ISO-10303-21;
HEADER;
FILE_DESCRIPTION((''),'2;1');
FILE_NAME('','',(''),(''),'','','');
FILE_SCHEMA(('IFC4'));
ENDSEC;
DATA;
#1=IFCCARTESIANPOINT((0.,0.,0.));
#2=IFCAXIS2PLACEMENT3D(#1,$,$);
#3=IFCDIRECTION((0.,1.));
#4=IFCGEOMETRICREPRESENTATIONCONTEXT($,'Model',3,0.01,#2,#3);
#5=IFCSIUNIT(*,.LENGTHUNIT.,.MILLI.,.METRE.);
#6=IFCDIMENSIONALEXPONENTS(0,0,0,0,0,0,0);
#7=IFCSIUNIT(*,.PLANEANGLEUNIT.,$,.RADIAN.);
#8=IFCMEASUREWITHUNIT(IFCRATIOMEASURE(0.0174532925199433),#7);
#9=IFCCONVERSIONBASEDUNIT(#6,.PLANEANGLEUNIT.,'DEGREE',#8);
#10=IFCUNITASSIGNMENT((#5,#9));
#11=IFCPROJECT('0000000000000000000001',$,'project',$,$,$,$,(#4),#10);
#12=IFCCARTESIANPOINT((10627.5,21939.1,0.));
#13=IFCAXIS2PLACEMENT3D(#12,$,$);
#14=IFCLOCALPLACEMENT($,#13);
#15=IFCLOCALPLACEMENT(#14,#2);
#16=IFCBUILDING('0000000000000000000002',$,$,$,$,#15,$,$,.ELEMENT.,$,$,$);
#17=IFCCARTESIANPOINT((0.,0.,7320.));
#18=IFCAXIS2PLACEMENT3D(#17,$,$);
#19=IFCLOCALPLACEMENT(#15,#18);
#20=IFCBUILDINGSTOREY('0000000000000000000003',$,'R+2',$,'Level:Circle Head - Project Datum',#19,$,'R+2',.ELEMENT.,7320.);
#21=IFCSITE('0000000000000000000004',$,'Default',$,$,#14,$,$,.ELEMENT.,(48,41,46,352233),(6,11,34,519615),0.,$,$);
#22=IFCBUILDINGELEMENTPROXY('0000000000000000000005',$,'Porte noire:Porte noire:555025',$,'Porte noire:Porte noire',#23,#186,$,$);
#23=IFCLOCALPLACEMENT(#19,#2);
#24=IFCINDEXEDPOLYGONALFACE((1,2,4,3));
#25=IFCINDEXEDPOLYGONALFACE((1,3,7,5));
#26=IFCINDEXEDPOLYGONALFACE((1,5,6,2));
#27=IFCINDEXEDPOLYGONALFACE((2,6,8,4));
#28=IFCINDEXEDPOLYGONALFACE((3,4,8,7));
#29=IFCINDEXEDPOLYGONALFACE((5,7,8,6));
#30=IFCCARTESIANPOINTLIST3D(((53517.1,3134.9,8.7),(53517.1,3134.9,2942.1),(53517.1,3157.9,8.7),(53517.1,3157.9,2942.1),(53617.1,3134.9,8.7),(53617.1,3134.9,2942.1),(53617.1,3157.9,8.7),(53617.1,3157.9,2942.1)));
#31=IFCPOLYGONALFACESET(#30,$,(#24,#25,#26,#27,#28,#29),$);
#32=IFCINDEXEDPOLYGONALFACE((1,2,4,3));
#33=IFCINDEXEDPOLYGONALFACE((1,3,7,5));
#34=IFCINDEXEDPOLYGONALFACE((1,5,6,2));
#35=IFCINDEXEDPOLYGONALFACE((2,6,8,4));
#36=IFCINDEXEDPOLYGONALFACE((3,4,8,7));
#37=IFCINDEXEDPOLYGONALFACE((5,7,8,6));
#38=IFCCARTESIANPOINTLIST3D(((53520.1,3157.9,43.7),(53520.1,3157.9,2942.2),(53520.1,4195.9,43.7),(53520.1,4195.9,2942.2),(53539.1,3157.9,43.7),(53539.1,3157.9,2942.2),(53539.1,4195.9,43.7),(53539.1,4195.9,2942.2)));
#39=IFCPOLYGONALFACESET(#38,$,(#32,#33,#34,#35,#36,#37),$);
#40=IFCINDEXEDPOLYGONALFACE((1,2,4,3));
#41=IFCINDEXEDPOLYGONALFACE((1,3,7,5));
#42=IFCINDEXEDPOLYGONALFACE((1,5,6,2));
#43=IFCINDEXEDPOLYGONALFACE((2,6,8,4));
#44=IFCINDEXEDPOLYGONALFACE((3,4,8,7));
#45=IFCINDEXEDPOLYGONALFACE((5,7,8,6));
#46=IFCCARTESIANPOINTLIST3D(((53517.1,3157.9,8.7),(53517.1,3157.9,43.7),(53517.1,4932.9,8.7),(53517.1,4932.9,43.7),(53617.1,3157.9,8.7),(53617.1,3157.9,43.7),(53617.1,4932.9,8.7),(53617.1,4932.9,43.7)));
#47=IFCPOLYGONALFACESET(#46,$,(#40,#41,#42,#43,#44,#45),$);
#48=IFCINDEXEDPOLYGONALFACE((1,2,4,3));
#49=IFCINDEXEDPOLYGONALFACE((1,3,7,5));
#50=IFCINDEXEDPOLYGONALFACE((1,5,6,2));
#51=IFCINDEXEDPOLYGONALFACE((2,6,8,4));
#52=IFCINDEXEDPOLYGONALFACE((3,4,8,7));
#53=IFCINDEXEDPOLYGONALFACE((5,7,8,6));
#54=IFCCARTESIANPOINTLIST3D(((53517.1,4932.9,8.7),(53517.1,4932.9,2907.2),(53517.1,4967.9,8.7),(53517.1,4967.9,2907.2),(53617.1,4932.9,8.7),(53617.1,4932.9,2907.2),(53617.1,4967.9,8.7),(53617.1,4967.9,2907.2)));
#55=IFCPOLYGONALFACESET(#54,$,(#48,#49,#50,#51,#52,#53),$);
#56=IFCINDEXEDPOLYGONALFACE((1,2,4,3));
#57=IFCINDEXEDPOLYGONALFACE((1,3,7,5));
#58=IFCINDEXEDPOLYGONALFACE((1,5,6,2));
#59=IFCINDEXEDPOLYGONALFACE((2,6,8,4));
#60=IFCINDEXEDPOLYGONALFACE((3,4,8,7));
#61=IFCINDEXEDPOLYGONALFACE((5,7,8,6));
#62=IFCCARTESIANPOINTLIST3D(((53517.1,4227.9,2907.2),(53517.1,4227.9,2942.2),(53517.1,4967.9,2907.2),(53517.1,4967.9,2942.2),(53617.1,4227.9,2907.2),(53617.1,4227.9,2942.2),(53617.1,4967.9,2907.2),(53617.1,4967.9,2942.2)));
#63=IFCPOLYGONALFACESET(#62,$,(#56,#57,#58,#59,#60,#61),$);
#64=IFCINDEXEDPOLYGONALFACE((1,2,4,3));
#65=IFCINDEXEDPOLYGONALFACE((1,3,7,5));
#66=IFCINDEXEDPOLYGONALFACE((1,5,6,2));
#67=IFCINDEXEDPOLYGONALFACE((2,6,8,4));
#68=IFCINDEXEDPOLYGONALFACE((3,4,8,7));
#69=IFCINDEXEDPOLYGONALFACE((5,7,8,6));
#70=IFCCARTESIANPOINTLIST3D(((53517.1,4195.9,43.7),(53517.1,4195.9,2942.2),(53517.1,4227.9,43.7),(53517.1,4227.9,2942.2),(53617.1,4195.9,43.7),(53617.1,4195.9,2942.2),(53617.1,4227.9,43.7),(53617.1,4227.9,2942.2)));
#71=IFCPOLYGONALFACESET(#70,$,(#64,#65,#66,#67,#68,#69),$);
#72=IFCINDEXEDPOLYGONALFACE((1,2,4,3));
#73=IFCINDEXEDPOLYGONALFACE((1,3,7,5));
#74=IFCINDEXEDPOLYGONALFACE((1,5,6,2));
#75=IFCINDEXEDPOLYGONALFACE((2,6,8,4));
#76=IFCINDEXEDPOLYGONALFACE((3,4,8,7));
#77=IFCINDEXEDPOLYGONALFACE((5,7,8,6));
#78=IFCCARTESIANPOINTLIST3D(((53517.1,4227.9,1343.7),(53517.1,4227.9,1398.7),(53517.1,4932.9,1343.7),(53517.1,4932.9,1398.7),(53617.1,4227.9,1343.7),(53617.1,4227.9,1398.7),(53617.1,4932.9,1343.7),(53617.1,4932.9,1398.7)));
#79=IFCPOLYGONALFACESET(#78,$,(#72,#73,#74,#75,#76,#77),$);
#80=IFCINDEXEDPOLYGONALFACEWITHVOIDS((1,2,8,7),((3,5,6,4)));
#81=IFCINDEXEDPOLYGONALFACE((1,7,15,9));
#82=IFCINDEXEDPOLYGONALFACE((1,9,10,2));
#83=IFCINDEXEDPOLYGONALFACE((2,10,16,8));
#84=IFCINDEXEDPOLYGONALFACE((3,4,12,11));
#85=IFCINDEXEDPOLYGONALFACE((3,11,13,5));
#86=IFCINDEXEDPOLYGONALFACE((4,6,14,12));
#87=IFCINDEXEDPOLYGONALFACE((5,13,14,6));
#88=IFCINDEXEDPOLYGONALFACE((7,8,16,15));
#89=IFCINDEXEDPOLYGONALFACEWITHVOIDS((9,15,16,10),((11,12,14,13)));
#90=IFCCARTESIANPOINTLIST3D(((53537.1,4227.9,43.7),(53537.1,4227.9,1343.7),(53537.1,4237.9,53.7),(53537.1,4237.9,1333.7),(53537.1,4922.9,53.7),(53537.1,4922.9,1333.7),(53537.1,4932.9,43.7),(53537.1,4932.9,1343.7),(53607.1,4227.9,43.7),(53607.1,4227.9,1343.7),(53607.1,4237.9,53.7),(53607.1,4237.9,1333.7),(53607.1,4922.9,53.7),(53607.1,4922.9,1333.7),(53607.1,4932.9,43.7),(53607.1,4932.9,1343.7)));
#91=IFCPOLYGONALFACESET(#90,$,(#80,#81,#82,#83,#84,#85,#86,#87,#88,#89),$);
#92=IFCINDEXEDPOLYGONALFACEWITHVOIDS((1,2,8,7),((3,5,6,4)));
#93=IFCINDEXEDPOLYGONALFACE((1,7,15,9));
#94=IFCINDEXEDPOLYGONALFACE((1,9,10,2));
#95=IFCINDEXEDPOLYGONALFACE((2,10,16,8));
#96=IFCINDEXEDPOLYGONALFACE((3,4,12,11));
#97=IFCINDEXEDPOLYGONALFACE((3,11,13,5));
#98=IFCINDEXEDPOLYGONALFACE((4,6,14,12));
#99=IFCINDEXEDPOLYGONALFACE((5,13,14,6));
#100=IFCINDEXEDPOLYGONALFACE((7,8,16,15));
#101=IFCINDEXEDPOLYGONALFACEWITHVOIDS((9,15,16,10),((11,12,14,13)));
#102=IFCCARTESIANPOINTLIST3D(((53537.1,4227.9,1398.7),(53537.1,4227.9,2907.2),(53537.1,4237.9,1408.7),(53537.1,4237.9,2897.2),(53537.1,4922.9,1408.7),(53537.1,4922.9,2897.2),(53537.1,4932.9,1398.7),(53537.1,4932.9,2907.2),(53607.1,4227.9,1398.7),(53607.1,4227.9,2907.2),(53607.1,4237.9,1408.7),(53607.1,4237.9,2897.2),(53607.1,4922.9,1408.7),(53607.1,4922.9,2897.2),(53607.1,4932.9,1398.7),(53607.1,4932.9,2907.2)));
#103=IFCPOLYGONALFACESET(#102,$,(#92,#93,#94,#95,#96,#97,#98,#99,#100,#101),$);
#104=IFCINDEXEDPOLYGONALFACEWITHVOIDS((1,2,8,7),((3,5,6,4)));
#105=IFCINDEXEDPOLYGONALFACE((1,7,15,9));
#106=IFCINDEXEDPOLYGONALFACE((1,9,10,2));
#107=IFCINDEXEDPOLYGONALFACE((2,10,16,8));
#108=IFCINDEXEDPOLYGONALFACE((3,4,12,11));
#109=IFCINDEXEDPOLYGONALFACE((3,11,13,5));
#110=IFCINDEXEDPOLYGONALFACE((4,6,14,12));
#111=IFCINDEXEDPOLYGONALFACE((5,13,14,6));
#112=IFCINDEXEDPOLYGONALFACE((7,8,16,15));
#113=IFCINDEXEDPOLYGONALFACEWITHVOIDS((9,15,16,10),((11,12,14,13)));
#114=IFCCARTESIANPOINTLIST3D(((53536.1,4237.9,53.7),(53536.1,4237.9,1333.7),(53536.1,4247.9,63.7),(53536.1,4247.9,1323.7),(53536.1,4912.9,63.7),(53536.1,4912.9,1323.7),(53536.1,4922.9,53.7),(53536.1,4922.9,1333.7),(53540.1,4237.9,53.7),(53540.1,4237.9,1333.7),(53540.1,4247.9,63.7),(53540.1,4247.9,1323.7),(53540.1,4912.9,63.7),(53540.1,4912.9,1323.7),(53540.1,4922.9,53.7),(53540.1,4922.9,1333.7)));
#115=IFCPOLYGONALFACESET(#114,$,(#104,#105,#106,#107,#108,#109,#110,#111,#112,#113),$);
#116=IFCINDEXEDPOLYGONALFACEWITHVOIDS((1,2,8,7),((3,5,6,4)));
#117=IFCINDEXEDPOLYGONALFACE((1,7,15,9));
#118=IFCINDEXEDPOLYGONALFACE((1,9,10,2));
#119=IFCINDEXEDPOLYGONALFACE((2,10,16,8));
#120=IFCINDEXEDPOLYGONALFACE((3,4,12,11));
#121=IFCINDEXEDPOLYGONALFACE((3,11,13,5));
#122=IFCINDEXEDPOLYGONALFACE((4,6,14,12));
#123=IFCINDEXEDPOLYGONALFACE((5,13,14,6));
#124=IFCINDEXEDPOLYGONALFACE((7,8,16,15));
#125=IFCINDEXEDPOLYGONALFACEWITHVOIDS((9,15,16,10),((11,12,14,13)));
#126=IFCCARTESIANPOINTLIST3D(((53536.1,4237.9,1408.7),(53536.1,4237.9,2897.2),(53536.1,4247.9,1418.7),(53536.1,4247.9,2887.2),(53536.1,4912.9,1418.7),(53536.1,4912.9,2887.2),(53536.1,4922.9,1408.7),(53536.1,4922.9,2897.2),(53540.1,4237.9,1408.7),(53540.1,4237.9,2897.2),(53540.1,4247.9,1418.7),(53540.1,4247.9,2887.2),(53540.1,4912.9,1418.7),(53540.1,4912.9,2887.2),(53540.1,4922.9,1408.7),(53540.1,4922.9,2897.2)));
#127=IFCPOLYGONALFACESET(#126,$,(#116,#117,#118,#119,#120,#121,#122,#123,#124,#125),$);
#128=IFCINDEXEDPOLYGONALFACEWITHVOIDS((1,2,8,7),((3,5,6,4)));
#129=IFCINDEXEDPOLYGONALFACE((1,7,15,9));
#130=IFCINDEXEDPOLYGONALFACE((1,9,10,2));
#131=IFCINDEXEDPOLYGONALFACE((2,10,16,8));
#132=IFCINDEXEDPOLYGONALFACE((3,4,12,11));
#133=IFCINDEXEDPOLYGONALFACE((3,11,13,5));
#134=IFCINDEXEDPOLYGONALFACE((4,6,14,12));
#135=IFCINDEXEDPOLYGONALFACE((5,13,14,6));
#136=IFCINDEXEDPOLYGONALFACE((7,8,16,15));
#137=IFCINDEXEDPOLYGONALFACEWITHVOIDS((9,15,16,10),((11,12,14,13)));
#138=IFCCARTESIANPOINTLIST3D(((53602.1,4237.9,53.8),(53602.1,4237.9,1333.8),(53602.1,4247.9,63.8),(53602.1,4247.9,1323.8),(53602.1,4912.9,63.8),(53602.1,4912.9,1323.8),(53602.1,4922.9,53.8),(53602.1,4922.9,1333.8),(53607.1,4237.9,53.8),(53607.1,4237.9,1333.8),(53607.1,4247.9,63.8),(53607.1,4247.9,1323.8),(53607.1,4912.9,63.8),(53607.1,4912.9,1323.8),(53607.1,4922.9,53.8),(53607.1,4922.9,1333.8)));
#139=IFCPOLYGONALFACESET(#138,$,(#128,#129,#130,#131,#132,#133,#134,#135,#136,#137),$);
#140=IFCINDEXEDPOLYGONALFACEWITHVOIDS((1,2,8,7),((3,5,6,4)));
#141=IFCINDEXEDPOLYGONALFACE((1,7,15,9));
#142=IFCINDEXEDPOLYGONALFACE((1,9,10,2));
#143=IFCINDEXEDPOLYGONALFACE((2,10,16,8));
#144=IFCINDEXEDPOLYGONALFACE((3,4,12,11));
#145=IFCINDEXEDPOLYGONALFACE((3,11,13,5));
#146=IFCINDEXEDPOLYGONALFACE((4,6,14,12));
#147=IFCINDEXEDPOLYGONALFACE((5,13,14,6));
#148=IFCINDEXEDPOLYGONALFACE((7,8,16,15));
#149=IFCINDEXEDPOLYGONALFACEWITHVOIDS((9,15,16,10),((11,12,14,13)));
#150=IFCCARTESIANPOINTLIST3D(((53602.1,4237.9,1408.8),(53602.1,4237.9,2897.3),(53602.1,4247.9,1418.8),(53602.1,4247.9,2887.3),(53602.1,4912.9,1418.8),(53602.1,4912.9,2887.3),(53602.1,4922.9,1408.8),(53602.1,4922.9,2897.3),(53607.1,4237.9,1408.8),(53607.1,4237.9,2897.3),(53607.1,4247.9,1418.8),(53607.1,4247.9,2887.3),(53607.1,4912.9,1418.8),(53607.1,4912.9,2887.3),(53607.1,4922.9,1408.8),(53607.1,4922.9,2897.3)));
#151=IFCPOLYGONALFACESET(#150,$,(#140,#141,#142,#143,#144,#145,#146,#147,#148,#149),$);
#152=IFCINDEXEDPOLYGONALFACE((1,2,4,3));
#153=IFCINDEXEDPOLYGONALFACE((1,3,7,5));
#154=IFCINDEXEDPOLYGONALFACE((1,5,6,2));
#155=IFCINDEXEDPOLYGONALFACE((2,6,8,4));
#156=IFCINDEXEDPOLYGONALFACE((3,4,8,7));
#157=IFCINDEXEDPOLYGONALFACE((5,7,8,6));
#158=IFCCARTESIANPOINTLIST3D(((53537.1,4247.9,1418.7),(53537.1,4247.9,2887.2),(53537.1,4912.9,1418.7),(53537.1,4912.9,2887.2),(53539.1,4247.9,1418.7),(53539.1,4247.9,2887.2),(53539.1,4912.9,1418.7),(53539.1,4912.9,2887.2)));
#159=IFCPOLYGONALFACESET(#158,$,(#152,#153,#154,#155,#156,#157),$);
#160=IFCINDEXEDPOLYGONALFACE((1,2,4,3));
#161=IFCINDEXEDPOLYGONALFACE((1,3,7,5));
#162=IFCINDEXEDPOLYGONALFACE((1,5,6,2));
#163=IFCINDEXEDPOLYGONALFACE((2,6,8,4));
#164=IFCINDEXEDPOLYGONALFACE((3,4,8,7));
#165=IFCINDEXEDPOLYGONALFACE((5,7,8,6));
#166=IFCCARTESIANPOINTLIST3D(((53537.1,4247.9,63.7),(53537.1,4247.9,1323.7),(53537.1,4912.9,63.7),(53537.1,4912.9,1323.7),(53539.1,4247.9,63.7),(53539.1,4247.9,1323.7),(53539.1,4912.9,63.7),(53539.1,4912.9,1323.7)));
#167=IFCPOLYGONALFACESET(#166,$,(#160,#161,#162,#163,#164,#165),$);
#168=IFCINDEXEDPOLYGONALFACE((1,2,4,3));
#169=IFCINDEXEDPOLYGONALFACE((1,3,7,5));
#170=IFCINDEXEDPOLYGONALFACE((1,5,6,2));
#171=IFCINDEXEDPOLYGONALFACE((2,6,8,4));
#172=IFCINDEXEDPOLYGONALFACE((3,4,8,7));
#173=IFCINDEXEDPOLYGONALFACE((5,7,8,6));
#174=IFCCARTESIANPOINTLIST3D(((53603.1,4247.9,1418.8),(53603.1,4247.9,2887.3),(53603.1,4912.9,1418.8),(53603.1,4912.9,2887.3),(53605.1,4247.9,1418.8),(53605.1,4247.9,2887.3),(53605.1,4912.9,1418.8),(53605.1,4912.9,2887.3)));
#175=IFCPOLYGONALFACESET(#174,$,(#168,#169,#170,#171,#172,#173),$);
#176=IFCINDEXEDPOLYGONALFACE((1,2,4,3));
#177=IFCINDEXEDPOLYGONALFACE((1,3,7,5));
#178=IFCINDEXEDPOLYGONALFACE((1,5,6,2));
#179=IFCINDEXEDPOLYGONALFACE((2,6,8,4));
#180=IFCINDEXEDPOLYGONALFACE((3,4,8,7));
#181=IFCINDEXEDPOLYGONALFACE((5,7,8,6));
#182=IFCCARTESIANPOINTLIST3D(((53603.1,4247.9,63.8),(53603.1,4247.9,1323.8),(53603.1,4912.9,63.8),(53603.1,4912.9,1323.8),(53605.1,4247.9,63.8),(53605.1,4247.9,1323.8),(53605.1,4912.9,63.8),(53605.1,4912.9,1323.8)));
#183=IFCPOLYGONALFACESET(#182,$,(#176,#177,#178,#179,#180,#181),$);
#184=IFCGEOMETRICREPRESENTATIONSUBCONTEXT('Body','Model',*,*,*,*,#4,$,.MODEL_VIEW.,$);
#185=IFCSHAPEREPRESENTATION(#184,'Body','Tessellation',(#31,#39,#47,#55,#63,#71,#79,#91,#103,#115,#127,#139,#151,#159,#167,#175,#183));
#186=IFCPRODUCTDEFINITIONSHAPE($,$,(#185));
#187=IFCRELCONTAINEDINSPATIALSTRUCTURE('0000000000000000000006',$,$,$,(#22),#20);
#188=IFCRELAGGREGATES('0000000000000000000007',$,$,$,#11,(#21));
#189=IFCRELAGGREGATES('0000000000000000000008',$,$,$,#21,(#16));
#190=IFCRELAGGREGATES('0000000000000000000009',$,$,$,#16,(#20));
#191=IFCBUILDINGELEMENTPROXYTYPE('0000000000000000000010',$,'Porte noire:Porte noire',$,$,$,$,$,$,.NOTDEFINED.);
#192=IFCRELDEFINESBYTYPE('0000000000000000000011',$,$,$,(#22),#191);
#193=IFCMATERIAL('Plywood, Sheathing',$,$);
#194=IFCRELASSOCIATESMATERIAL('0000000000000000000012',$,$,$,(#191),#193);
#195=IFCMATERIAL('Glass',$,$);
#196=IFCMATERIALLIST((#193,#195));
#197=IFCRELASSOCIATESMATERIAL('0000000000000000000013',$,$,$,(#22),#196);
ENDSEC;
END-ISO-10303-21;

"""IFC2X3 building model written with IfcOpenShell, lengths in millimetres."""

from ifc_helpers import new_model, entity, si_unit, converted_unit, direction, frame, frame_2d, origin, origin_2d_with_axis, place, context, subcontext, project, spatial, polyline, rectangle, outline, extrude, source, transform, mapped, material, material_list, type_object, type_shapes, element, save


model = new_model("IFC2X3")

# Units and contexts
model_context = context("Model", 3, precision=0.01, world=origin(), true_north=direction((0.0, 1.0)))
body_context = subcontext(model_context, "Body", "Model", "MODEL_VIEW")
ifc_project = project(units=[si_unit("LENGTHUNIT", "METRE", prefix="MILLI"), converted_unit("PLANEANGLEUNIT", "DEGREE", entity("IfcRatioMeasure", 0.0174532925199433), si_unit("PLANEANGLEUNIT", "RADIAN"), dimensions=[0, 0, 0, 0, 0, 0, 0])], contexts=[model_context])

# Site, building, storey
site_placement = place(None, frame((10627.5, 21939.1, 0.0)))
site = spatial("IfcSite", under=ifc_project, at=site_placement, Name="Default", CompositionType="ELEMENT", RefLatitude=(48, 41, 46, 352233), RefLongitude=(6, 11, 34, 519615), RefElevation=0.0)
building_placement = place(site_placement, origin())
building = spatial("IfcBuilding", under=site, at=building_placement, CompositionType="ELEMENT")
storey_placement = place(building_placement, frame((0.0, 0.0, 7320.0)))
storey = spatial("IfcBuildingStorey", under=building, at=storey_placement, Name="R+2", ObjectType="Level:Circle Head - Project Datum", LongName="R+2", CompositionType="ELEMENT", Elevation=7320.0)

# Building element proxy
ifc_material_1 = material(Name="Glass")
ifc_material_2 = material(Name="Plywood, Sheathing")
ifc_material_list_1 = material_list([ifc_material_2, ifc_material_1])
building_element_proxy_type_1 = type_object("IfcBuildingElementProxyType", Name="Porte noire:Porte noire", PredefinedType="NOTDEFINED", material=ifc_material_2)
shared_shape_1 = source(origin(), body_context, "Body", "SweptSolid", [
    extrude(rectangle(XDim=23.0, YDim=100.0, at=frame_2d((0.0, 0.0), x_axis=(1.0, 0.0))), frame((-950.9, 50.0, 8.7), z_axis=(0.0, 0.0, 1.0), x_axis=(-1.0, 0.0, 0.0)), (0.0, 0.0, 1.0), 2933.3),
    extrude(rectangle(XDim=1038.0, YDim=19.0, at=frame_2d((0.0, 0.0), x_axis=(1.0, 0.0))), frame((-420.4, 87.5, 43.7), z_axis=(0.0, 0.0, 1.0), x_axis=(-1.0, 0.0, 0.0)), (0.0, 0.0, 1.0), 2898.5),
    extrude(rectangle(XDim=1775.0, YDim=100.0, at=origin_2d_with_axis()), frame((-51.9, 50.0, 8.7), z_axis=(0.0, 0.0, 1.0), x_axis=(-1.0, 0.0, 0.0)), (0.0, 0.0, 1.0), 35.0),
    extrude(rectangle(XDim=35.0, YDim=100.0, at=origin_2d_with_axis()), frame((853.1, 50.0, 8.7), z_axis=(0.0, 0.0, 1.0), x_axis=(-1.0, 0.0, 0.0)), (0.0, 0.0, 1.0), 2898.5),
    extrude(rectangle(XDim=740.0, YDim=100.0, at=origin_2d_with_axis()), frame((500.6, 50.0, 2907.2), z_axis=(0.0, 0.0, 1.0), x_axis=(-1.0, 0.0, 0.0)), (0.0, 0.0, 1.0), 35.0),
    extrude(rectangle(XDim=32.0, YDim=100.0, at=origin_2d_with_axis()), frame((114.6, 50.0, 43.7), z_axis=(0.0, 0.0, 1.0), x_axis=(-1.0, 0.0, 0.0)), (0.0, 0.0, 1.0), 2898.5),
    extrude(rectangle(XDim=705.0, YDim=100.0, at=origin_2d_with_axis()), frame((483.1, 50.0, 1343.7), z_axis=(0.0, 0.0, 1.0), x_axis=(-1.0, 0.0, 0.0)), (0.0, 0.0, 1.0), 55.0),
    extrude(outline(polyline([(-352.5, -650.0), (352.5, -650.0), (352.5, 650.0), (-352.5, 650.0), (-352.5, -650.0)]), holes=[polyline([(342.5, 640.0), (342.5, -640.0), (-342.5, -640.0), (-342.5, 640.0), (342.5, 640.0)])]), frame((483.1, 10.0, 693.7), z_axis=(0.0, 1.0, 0.0), x_axis=(1.0, 0.0, 0.0)), (0.0, 0.0, 1.0), 70.0),
    extrude(outline(polyline([(-754.2, -352.5), (754.2, -352.5), (754.2, 352.5), (-754.2, 352.5), (-754.2, -352.5)]), holes=[polyline([(744.2, 342.5), (744.2, -342.5), (-744.2, -342.5), (-744.2, 342.5), (744.2, 342.5)])]), frame((483.1, 10.0, 2153.0), z_axis=(0.0, 1.0, 0.0), x_axis=(0.0, 0.0, 1.0)), (0.0, 0.0, 1.0), 70.0),
    extrude(outline(polyline([(-640.0, -342.5), (640.0, -342.5), (640.0, 342.5), (-640.0, 342.5), (-640.0, -342.5)]), holes=[polyline([(630.0, 332.5), (630.0, -332.5), (-630.0, -332.5), (-630.0, 332.5), (630.0, 332.5)])]), frame((483.1, 77.0, 693.7), z_axis=(0.0, 1.0, 0.0), x_axis=(0.0, 0.0, 1.0)), (0.0, 0.0, 1.0), 4.0),
    extrude(outline(polyline([(-744.2, -342.5), (744.2, -342.5), (744.2, 342.5), (-744.2, 342.5), (-744.2, -342.5)]), holes=[polyline([(734.2, 332.5), (734.2, -332.5), (-734.2, -332.5), (-734.2, 332.5), (734.2, 332.5)])]), frame((483.1, 77.0, 2153.0), z_axis=(0.0, 1.0, 0.0), x_axis=(0.0, 0.0, 1.0)), (0.0, 0.0, 1.0), 4.0),
    extrude(outline(polyline([(-640.0, -342.5), (640.0, -342.5), (640.0, 342.5), (-640.0, 342.5), (-640.0, -342.5)]), holes=[polyline([(630.0, 332.5), (630.0, -332.5), (-630.0, -332.5), (-630.0, 332.5), (630.0, 332.5)])]), frame((483.1, 10.0, 693.8), z_axis=(0.0, 1.0, 0.0), x_axis=(0.0, 0.0, 1.0)), (0.0, 0.0, 1.0), 5.0),
    extrude(outline(polyline([(-744.2, -342.5), (744.2, -342.5), (744.2, 342.5), (-744.2, 342.5), (-744.2, -342.5)]), holes=[polyline([(734.2, 332.5), (734.2, -332.5), (-734.2, -332.5), (-734.2, 332.5), (734.2, 332.5)])]), frame((483.1, 10.0, 2153.0), z_axis=(0.0, 1.0, 0.0), x_axis=(0.0, 0.0, 1.0)), (0.0, 0.0, 1.0), 5.0),
    extrude(rectangle(XDim=665.0, YDim=2.0, at=frame_2d((0.0, 0.0), x_axis=(1.0, 0.0))), frame((483.1, 79.0, 1418.7), z_axis=(0.0, 0.0, 1.0), x_axis=(-1.0, 0.0, 0.0)), (0.0, 0.0, 1.0), 1468.5),
    extrude(rectangle(XDim=665.0, YDim=2.0, at=frame_2d((0.0, 0.0), x_axis=(1.0, 0.0))), frame((483.1, 79.0, 63.7), z_axis=(0.0, 0.0, 1.0), x_axis=(-1.0, 0.0, 0.0)), (0.0, 0.0, 1.0), 1260.0),
    extrude(rectangle(XDim=665.0, YDim=2.0, at=frame_2d((0.0, 0.0), x_axis=(1.0, 0.0))), frame((483.1, 13.0, 1418.8), z_axis=(0.0, 0.0, 1.0), x_axis=(-1.0, 0.0, 0.0)), (0.0, 0.0, 1.0), 1468.5),
    extrude(rectangle(XDim=665.0, YDim=2.0, at=frame_2d((0.0, 0.0), x_axis=(1.0, 0.0))), frame((483.1, 13.0, 63.8), z_axis=(0.0, 0.0, 1.0), x_axis=(-1.0, 0.0, 0.0)), (0.0, 0.0, 1.0), 1260.0),
])
type_shapes(building_element_proxy_type_1, [shared_shape_1])
proxy_1_placement = place(storey_placement, frame((53617.1, 4097.3, 0.0), z_axis=(0.0, 0.0, 1.0), x_axis=(0.0, 1.0, 0.0)))
element("IfcBuildingElementProxy", 1, at=proxy_1_placement, inside=storey, type_object=building_element_proxy_type_1, material=ifc_material_list_1, Name="Porte noire:Porte noire:555025", ObjectType="Porte noire:Porte noire", context=body_context, shape_type="MappedRepresentation", body=[
    mapped(shared_shape_1, transform((0.0, 0.0, 0.0), scale=1.0)),
])

save(model, "model.ifc")
